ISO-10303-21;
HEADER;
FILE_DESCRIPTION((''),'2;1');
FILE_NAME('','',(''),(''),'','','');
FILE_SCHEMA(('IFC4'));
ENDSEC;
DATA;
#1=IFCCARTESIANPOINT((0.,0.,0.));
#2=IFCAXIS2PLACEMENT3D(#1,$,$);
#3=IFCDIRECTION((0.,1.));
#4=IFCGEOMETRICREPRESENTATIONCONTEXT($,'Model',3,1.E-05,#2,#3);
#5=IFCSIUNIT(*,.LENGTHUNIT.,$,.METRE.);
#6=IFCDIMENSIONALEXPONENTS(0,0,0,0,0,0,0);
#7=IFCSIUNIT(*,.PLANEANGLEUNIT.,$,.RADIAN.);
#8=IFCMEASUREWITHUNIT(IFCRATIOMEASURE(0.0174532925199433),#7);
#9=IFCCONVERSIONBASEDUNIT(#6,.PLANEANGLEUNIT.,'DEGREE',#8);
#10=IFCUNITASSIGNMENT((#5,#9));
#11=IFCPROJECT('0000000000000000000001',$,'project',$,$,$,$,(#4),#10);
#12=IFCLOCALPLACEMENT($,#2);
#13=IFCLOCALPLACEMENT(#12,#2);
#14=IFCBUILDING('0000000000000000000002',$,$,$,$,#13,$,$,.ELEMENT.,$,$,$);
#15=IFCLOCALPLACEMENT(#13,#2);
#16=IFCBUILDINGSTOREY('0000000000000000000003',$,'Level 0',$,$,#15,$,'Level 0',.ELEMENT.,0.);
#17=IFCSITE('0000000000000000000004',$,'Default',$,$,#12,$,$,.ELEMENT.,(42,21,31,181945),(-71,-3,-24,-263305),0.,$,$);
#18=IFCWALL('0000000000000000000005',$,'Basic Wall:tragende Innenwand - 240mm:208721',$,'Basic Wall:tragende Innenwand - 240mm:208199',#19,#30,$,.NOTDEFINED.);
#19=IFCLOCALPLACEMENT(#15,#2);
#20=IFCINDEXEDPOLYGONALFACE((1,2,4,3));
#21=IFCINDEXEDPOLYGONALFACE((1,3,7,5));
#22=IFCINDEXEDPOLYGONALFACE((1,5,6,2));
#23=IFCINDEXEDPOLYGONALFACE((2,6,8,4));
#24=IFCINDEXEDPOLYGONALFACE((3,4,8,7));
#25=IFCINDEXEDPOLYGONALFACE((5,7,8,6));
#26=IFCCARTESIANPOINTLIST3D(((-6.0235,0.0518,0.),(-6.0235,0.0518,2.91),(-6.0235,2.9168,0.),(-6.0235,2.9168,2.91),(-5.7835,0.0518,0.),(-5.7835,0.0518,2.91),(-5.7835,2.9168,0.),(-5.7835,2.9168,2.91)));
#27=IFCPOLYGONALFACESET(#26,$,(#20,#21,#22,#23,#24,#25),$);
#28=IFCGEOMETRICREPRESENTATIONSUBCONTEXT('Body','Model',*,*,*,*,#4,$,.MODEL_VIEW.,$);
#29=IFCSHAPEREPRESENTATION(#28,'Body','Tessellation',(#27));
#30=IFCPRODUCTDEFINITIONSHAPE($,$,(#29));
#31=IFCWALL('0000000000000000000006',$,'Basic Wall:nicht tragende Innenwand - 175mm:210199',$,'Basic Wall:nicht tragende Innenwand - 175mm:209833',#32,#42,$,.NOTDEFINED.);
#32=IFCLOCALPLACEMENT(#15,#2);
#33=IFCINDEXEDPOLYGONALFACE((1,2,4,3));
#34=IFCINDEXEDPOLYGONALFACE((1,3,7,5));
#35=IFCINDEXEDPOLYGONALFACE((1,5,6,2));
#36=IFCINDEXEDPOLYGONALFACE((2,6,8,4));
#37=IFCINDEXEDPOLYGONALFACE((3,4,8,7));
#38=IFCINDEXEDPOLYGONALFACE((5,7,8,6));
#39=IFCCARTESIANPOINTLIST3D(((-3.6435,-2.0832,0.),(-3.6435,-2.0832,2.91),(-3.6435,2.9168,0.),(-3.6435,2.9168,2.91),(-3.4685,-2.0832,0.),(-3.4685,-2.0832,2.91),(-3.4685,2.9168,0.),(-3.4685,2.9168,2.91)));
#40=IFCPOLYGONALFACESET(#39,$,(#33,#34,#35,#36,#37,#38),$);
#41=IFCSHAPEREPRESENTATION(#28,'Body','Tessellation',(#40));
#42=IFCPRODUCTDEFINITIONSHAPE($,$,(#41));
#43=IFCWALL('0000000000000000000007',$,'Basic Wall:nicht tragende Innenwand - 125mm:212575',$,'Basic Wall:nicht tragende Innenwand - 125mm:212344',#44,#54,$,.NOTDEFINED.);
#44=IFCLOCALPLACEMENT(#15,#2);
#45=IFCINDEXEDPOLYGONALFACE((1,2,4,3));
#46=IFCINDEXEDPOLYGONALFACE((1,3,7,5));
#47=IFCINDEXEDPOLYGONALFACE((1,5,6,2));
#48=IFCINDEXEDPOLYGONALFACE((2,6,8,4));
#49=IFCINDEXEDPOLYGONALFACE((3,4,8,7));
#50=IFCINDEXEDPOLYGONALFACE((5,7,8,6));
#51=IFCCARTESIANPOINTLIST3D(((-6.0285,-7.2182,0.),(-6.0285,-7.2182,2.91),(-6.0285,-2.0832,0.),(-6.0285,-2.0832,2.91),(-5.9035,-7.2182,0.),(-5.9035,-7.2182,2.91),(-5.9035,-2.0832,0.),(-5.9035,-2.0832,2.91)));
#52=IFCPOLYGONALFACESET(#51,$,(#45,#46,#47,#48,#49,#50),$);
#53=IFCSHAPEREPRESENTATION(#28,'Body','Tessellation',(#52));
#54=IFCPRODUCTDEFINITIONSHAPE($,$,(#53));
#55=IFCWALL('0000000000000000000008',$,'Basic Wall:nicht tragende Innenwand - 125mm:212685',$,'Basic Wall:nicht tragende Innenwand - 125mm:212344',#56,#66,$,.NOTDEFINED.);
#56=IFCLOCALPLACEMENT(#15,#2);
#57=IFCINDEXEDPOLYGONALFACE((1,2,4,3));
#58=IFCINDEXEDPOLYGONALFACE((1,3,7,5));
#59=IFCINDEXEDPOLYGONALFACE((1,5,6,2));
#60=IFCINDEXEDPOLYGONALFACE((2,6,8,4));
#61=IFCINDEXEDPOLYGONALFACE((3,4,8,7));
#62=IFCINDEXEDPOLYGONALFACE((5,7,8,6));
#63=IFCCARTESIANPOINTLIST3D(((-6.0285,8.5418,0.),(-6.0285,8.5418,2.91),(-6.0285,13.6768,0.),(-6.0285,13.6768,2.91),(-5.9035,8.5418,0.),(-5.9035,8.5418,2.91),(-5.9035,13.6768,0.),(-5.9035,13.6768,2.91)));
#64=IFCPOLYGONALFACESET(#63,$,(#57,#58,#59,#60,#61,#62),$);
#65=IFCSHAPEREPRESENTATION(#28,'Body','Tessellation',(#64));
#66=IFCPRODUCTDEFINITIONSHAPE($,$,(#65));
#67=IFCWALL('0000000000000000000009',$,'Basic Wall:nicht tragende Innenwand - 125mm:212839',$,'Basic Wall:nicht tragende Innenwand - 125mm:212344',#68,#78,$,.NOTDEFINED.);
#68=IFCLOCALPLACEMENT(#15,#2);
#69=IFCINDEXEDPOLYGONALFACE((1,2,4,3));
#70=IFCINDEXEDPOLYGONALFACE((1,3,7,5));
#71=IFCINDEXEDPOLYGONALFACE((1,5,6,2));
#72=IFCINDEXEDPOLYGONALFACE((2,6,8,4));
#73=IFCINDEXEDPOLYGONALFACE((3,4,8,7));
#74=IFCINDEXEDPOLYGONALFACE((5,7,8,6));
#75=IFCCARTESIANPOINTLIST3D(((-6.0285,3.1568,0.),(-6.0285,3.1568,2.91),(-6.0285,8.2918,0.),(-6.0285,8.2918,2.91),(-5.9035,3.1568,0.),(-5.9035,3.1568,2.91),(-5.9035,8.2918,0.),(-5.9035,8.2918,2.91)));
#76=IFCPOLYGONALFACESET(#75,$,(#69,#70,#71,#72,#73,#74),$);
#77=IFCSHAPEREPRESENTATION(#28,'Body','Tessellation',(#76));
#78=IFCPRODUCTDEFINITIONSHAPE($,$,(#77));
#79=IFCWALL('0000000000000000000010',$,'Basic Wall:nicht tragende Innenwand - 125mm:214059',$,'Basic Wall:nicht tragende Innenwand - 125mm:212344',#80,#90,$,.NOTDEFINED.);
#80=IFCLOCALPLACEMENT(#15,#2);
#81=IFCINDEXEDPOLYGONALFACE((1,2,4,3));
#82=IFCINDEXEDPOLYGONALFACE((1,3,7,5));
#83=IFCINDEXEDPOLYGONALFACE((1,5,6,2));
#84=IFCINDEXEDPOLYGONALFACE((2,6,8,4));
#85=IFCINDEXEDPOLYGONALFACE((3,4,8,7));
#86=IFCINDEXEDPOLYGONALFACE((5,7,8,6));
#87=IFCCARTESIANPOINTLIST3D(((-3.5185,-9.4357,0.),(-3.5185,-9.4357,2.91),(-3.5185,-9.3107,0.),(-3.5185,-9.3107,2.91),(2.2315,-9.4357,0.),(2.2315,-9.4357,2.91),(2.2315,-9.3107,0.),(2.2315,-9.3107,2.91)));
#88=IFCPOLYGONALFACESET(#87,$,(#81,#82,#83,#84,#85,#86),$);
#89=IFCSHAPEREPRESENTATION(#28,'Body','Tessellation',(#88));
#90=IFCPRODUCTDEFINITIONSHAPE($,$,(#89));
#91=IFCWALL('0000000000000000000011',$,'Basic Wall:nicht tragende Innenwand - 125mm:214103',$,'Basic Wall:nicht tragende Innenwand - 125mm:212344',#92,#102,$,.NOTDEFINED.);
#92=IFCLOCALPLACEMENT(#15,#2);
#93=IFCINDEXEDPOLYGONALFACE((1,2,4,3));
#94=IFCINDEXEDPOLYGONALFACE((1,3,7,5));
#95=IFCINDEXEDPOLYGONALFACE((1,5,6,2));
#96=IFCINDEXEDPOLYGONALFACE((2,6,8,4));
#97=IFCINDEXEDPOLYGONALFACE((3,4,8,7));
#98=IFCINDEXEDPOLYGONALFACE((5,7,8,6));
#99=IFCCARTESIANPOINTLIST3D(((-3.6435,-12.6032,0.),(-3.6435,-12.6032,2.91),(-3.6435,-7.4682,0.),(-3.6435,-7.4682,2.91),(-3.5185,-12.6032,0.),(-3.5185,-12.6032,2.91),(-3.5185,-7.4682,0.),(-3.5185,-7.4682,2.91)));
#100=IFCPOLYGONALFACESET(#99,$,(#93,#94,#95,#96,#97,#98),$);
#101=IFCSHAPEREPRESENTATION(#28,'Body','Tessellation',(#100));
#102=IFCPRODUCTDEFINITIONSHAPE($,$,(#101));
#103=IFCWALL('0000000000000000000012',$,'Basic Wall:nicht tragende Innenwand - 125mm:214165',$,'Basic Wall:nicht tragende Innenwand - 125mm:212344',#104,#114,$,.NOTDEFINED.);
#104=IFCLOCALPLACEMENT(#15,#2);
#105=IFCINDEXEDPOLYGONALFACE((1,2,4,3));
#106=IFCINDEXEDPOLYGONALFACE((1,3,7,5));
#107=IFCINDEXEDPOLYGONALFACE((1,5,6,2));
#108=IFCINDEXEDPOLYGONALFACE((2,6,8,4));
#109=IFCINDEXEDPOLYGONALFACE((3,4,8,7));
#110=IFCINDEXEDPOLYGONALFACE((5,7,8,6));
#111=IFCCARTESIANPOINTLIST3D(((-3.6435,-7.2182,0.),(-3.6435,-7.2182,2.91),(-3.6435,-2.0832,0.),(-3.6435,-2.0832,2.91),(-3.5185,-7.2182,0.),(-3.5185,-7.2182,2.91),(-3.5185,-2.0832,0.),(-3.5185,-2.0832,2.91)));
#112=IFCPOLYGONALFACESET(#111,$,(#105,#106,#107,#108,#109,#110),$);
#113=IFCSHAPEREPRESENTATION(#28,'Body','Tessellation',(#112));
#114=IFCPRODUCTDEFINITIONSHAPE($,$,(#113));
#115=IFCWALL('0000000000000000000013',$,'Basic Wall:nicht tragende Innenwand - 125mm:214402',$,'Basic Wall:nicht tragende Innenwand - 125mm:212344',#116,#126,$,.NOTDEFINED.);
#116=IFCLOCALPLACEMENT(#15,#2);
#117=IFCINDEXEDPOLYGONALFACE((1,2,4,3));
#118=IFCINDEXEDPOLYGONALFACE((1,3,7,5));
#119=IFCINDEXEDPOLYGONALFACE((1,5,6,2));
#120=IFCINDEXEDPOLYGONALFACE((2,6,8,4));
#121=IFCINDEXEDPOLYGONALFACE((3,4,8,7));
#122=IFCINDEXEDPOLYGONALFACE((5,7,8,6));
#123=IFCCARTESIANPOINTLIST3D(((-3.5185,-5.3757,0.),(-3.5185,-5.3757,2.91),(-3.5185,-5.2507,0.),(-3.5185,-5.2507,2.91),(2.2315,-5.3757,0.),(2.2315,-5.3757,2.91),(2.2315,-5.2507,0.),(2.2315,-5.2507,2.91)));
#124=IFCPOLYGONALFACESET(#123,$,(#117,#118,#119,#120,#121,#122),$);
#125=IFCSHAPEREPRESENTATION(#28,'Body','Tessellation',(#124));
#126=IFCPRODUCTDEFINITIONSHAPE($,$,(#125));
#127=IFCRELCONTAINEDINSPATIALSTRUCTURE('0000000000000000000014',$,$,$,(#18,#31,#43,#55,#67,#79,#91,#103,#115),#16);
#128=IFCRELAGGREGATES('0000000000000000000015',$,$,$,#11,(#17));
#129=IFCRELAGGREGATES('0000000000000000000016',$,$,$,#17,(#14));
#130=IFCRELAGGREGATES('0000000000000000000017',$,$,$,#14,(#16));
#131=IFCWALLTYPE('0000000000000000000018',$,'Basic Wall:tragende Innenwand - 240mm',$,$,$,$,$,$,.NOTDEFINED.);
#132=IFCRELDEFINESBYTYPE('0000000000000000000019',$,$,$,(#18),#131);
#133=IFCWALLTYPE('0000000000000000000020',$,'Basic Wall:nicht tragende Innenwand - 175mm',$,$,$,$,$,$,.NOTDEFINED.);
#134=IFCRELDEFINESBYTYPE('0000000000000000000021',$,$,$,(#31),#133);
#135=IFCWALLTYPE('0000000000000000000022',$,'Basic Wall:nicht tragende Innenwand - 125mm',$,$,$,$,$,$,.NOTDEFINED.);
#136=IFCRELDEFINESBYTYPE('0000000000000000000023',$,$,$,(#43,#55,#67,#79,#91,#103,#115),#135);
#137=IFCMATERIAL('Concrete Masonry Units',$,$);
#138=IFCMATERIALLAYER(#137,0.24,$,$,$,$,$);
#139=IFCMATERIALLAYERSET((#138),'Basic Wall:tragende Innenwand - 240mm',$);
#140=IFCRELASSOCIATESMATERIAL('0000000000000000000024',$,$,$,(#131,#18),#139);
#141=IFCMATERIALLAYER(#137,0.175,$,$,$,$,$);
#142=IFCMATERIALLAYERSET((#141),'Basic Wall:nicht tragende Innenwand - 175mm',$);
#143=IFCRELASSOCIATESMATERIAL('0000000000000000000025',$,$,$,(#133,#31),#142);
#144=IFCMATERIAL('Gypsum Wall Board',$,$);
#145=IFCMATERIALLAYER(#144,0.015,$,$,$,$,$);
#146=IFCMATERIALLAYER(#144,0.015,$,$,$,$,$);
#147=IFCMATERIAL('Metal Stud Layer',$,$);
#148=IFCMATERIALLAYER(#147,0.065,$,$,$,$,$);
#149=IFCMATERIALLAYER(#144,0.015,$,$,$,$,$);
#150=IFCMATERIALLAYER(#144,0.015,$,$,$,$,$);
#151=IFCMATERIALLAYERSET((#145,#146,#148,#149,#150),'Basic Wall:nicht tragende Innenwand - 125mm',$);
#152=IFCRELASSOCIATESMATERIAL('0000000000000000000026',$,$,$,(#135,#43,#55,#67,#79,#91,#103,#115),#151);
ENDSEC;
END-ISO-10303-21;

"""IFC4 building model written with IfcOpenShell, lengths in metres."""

from ifc_helpers import new_model, entity, si_unit, converted_unit, direction, frame, frame_2d, origin, place, context, subcontext, project, spatial, polyline, rectangle, extrude, clip, bounded_halfspace, material, layer, layer_set, layer_usage, type_object, element, save


model = new_model("IFC4")

# Units and contexts
model_context = context("Model", 3, precision=1e-05, world=origin(), true_north=direction((0.0, 1.0)))
body_context = subcontext(model_context, "Body", "Model", "MODEL_VIEW")
ifc_project = project(units=[si_unit("LENGTHUNIT", "METRE"), converted_unit("PLANEANGLEUNIT", "DEGREE", entity("IfcRatioMeasure", 0.0174532925199433), si_unit("PLANEANGLEUNIT", "RADIAN"), dimensions=[0, 0, 0, 0, 0, 0, 0])], contexts=[model_context])

# Site, building, storey
site_placement = place(None, origin())
site = spatial("IfcSite", under=ifc_project, at=site_placement, Name="Default", CompositionType="ELEMENT", RefLatitude=(42, 21, 31, 181945), RefLongitude=(-71, -3, -24, -263305), RefElevation=0.0)
building_placement = place(site_placement, origin())
building = spatial("IfcBuilding", under=site, at=building_placement, CompositionType="ELEMENT")
storey_placement = place(building_placement, origin())
storey = spatial("IfcBuildingStorey", under=building, at=storey_placement, Name="Level 0", LongName="Level 0", CompositionType="ELEMENT", Elevation=0.0)

# Walls
ifc_material_1 = material(Name="Concrete Masonry Units")
ifc_layer_1 = layer(ifc_material_1, 0.24)
ifc_layer_set_1 = layer_set([ifc_layer_1], Name="Basic Wall:tragende Innenwand - 240mm")
ifc_layer_usage_1 = layer_usage(ifc_layer_set_1, "AXIS2", "NEGATIVE", 0.12)
wall_type_1 = type_object("IfcWallType", Name="Basic Wall:tragende Innenwand - 240mm", PredefinedType="NOTDEFINED", material=ifc_layer_set_1)
wall_1_placement = place(storey_placement, frame((-5.9035, 2.9168, 0.0), z_axis=(0.0, 0.0, 1.0), x_axis=(0.0, -1.0, 0.0)))
element("IfcWall", 1, at=wall_1_placement, inside=storey, type_object=wall_type_1, material=ifc_layer_usage_1, Name="Basic Wall:tragende Innenwand - 240mm:208721", ObjectType="Basic Wall:tragende Innenwand - 240mm:208199", PredefinedType="NOTDEFINED", context=body_context, shape_type="Clipping", body=[
    clip(extrude(rectangle(XDim=2.865, YDim=0.24, at=frame_2d((1.4325, 0.0), x_axis=(-1.0, 0.0))), origin(), (0.0, 0.0, 1.0), 2.91), bounded_halfspace(frame((0.0, -0.12, 2.91), z_axis=(0.0, 0.0, -1.0), x_axis=(1.0, 0.0, 0.0)), True, frame((0.0, -0.12, 2.91)), polyline([(0.0, 0.0), (2.865, 0.0), (2.865, 0.24), (0.0, 0.24), (0.0, 0.0)]))),
])
ifc_layer_2 = layer(ifc_material_1, 0.175)
ifc_layer_set_2 = layer_set([ifc_layer_2], Name="Basic Wall:nicht tragende Innenwand - 175mm")
ifc_layer_usage_2 = layer_usage(ifc_layer_set_2, "AXIS2", "NEGATIVE", 0.0875)
wall_type_2 = type_object("IfcWallType", Name="Basic Wall:nicht tragende Innenwand - 175mm", PredefinedType="NOTDEFINED", material=ifc_layer_set_2)
wall_2_placement = place(storey_placement, frame((-3.556, 2.9168, 0.0), z_axis=(0.0, 0.0, 1.0), x_axis=(0.0, -1.0, 0.0)))
element("IfcWall", 2, at=wall_2_placement, inside=storey, type_object=wall_type_2, material=ifc_layer_usage_2, Name="Basic Wall:nicht tragende Innenwand - 175mm:210199", ObjectType="Basic Wall:nicht tragende Innenwand - 175mm:209833", PredefinedType="NOTDEFINED", context=body_context, shape_type="Clipping", body=[
    clip(extrude(rectangle(XDim=5.0, YDim=0.175, at=frame_2d((2.5, 0.0), x_axis=(-1.0, 0.0))), origin(), (0.0, 0.0, 1.0), 2.91), bounded_halfspace(frame((0.0, -0.0875, 2.91), z_axis=(0.0, 0.0, -1.0), x_axis=(1.0, 0.0, 0.0)), True, frame((0.0, -0.0875, 2.91)), polyline([(0.0, 0.0), (5.0, 0.0), (5.0, 0.125), (5.0, 0.175), (4.76, 0.175), (0.0, 0.175), (0.0, 0.0)]))),
])
ifc_material_2 = material(Name="Gypsum Wall Board")
ifc_layer_3 = layer(ifc_material_2, 0.015)
ifc_layer_4 = layer(ifc_material_2, 0.015)
ifc_material_3 = material(Name="Metal Stud Layer")
ifc_layer_5 = layer(ifc_material_3, 0.065)
ifc_layer_6 = layer(ifc_material_2, 0.015)
ifc_layer_7 = layer(ifc_material_2, 0.015)
ifc_layer_set_3 = layer_set([ifc_layer_3, ifc_layer_4, ifc_layer_5, ifc_layer_6, ifc_layer_7], Name="Basic Wall:nicht tragende Innenwand - 125mm")
ifc_layer_usage_3 = layer_usage(ifc_layer_set_3, "AXIS2", "NEGATIVE", 0.0625)
wall_type_3 = type_object("IfcWallType", Name="Basic Wall:nicht tragende Innenwand - 125mm", PredefinedType="NOTDEFINED", material=ifc_layer_set_3)
wall_3_placement = place(storey_placement, frame((-5.966, -2.0832, 0.0), z_axis=(0.0, 0.0, 1.0), x_axis=(0.0, -1.0, 0.0)))
element("IfcWall", 3, at=wall_3_placement, inside=storey, type_object=wall_type_3, material=ifc_layer_usage_3, Name="Basic Wall:nicht tragende Innenwand - 125mm:212575", ObjectType="Basic Wall:nicht tragende Innenwand - 125mm:212344", PredefinedType="NOTDEFINED", context=body_context, shape_type="Clipping", body=[
    clip(extrude(rectangle(XDim=5.135, YDim=0.125, at=frame_2d((2.5675, 0.0), x_axis=(-1.0, 0.0))), origin(), (0.0, 0.0, 1.0), 2.91), bounded_halfspace(frame((0.0, -0.0625, 2.91), z_axis=(0.0, 0.0, -1.0), x_axis=(1.0, 0.0, 0.0)), True, frame((0.0, -0.0625, 2.91)), polyline([(0.0, 0.0), (5.135, 0.0), (5.135, 0.125), (0.0, 0.125), (0.0, 0.0)]))),
])
ifc_layer_usage_4 = layer_usage(ifc_layer_set_3, "AXIS2", "NEGATIVE", 0.0625)
wall_4_placement = place(storey_placement, frame((-5.966, 13.6768, 0.0), z_axis=(0.0, 0.0, 1.0), x_axis=(0.0, -1.0, 0.0)))
element("IfcWall", 4, at=wall_4_placement, inside=storey, type_object=wall_type_3, material=ifc_layer_usage_4, Name="Basic Wall:nicht tragende Innenwand - 125mm:212685", ObjectType="Basic Wall:nicht tragende Innenwand - 125mm:212344", PredefinedType="NOTDEFINED", context=body_context, shape_type="Clipping", body=[
    clip(extrude(rectangle(XDim=5.135, YDim=0.125, at=frame_2d((2.5675, 0.0), x_axis=(-1.0, 0.0))), origin(), (0.0, 0.0, 1.0), 2.91), bounded_halfspace(frame((0.0, -0.0625, 2.91), z_axis=(0.0, 0.0, -1.0), x_axis=(1.0, 0.0, 0.0)), True, frame((0.0, -0.0625, 2.91)), polyline([(0.0, 0.0), (5.135, 0.0), (5.135, 0.125), (0.0, 0.125), (0.0, 0.0)]))),
])
ifc_layer_usage_5 = layer_usage(ifc_layer_set_3, "AXIS2", "NEGATIVE", 0.0625)
wall_5_placement = place(storey_placement, frame((-5.966, 8.2918, 0.0), z_axis=(0.0, 0.0, 1.0), x_axis=(0.0, -1.0, 0.0)))
element("IfcWall", 5, at=wall_5_placement, inside=storey, type_object=wall_type_3, material=ifc_layer_usage_5, Name="Basic Wall:nicht tragende Innenwand - 125mm:212839", ObjectType="Basic Wall:nicht tragende Innenwand - 125mm:212344", PredefinedType="NOTDEFINED", context=body_context, shape_type="Clipping", body=[
    clip(extrude(rectangle(XDim=5.135, YDim=0.125, at=frame_2d((2.5675, 0.0), x_axis=(-1.0, 0.0))), origin(), (0.0, 0.0, 1.0), 2.91), bounded_halfspace(frame((0.0, -0.0625, 2.91), z_axis=(0.0, 0.0, -1.0), x_axis=(1.0, 0.0, 0.0)), True, frame((0.0, -0.0625, 2.91)), polyline([(0.0, 0.0), (5.135, 0.0), (5.135, 0.125), (0.0, 0.125), (0.0, 0.0)]))),
])
ifc_layer_usage_6 = layer_usage(ifc_layer_set_3, "AXIS2", "NEGATIVE", 0.0625)
wall_6_placement = place(storey_placement, frame((-3.5185, -9.3732, 0.0)))
element("IfcWall", 6, at=wall_6_placement, inside=storey, type_object=wall_type_3, material=ifc_layer_usage_6, Name="Basic Wall:nicht tragende Innenwand - 125mm:214059", ObjectType="Basic Wall:nicht tragende Innenwand - 125mm:212344", PredefinedType="NOTDEFINED", context=body_context, shape_type="Clipping", body=[
    clip(extrude(rectangle(XDim=5.75, YDim=0.125, at=frame_2d((2.875, 0.0), x_axis=(-1.0, 0.0))), origin(), (0.0, 0.0, 1.0), 2.91), bounded_halfspace(frame((0.0, -0.0625, 2.91), z_axis=(0.0, 0.0, -1.0), x_axis=(0.0, -1.0, 0.0)), True, frame((0.0, -0.0625, 2.91)), polyline([(0.0, 0.0), (5.75, 0.0), (5.75, 0.125), (0.0, 0.125), (0.0, 0.0)]))),
])
ifc_layer_usage_7 = layer_usage(ifc_layer_set_3, "AXIS2", "NEGATIVE", 0.0625)
wall_7_placement = place(storey_placement, frame((-3.581, -7.4682, 0.0), z_axis=(0.0, 0.0, 1.0), x_axis=(0.0, -1.0, 0.0)))
element("IfcWall", 7, at=wall_7_placement, inside=storey, type_object=wall_type_3, material=ifc_layer_usage_7, Name="Basic Wall:nicht tragende Innenwand - 125mm:214103", ObjectType="Basic Wall:nicht tragende Innenwand - 125mm:212344", PredefinedType="NOTDEFINED", context=body_context, shape_type="Clipping", body=[
    clip(extrude(rectangle(XDim=5.135, YDim=0.125, at=frame_2d((2.5675, 0.0), x_axis=(-1.0, 0.0))), origin(), (0.0, 0.0, 1.0), 2.91), bounded_halfspace(frame((0.0, -0.0625, 2.91), z_axis=(0.0, 0.0, -1.0), x_axis=(1.0, 0.0, 0.0)), True, frame((0.0, -0.0625, 2.91)), polyline([(0.0, 0.0), (5.135, 0.0), (5.135, 0.125), (1.9675, 0.125), (1.8425, 0.125), (0.0, 0.125), (0.0, 0.0)]))),
])
ifc_layer_usage_8 = layer_usage(ifc_layer_set_3, "AXIS2", "NEGATIVE", 0.0625)
wall_8_placement = place(storey_placement, frame((-3.581, -2.0832, 0.0), z_axis=(0.0, 0.0, 1.0), x_axis=(0.0, -1.0, 0.0)))
element("IfcWall", 8, at=wall_8_placement, inside=storey, type_object=wall_type_3, material=ifc_layer_usage_8, Name="Basic Wall:nicht tragende Innenwand - 125mm:214165", ObjectType="Basic Wall:nicht tragende Innenwand - 125mm:212344", PredefinedType="NOTDEFINED", context=body_context, shape_type="Clipping", body=[
    clip(extrude(rectangle(XDim=5.135, YDim=0.125, at=frame_2d((2.5675, 0.0), x_axis=(-1.0, 0.0))), origin(), (0.0, 0.0, 1.0), 2.91), bounded_halfspace(frame((0.0, -0.0625, 2.91), z_axis=(0.0, 0.0, -1.0), x_axis=(1.0, 0.0, 0.0)), True, frame((0.0, -0.0625, 2.91)), polyline([(0.0, 0.0), (5.135, 0.0), (5.135, 0.125), (3.2925, 0.125), (3.1675, 0.125), (0.0, 0.125), (0.0, 0.0)]))),
])
ifc_layer_usage_9 = layer_usage(ifc_layer_set_3, "AXIS2", "POSITIVE", -0.0625)
wall_9_placement = place(storey_placement, frame((-3.5185, -5.3132, 0.0)))
element("IfcWall", 9, at=wall_9_placement, inside=storey, type_object=wall_type_3, material=ifc_layer_usage_9, Name="Basic Wall:nicht tragende Innenwand - 125mm:214402", ObjectType="Basic Wall:nicht tragende Innenwand - 125mm:212344", PredefinedType="NOTDEFINED", context=body_context, shape_type="Clipping", body=[
    clip(extrude(rectangle(XDim=5.75, YDim=0.125, at=frame_2d((2.875, 0.0), x_axis=(-1.0, 0.0))), origin(), (0.0, 0.0, 1.0), 2.91), bounded_halfspace(frame((0.0, -0.0625, 2.91), z_axis=(0.0, 0.0, -1.0), x_axis=(0.0, -1.0, 0.0)), True, frame((0.0, -0.0625, 2.91)), polyline([(0.0, 0.0), (5.75, 0.0), (5.75, 0.125), (0.0, 0.125), (0.0, 0.0)]))),
])

save(model, "model.ifc")
